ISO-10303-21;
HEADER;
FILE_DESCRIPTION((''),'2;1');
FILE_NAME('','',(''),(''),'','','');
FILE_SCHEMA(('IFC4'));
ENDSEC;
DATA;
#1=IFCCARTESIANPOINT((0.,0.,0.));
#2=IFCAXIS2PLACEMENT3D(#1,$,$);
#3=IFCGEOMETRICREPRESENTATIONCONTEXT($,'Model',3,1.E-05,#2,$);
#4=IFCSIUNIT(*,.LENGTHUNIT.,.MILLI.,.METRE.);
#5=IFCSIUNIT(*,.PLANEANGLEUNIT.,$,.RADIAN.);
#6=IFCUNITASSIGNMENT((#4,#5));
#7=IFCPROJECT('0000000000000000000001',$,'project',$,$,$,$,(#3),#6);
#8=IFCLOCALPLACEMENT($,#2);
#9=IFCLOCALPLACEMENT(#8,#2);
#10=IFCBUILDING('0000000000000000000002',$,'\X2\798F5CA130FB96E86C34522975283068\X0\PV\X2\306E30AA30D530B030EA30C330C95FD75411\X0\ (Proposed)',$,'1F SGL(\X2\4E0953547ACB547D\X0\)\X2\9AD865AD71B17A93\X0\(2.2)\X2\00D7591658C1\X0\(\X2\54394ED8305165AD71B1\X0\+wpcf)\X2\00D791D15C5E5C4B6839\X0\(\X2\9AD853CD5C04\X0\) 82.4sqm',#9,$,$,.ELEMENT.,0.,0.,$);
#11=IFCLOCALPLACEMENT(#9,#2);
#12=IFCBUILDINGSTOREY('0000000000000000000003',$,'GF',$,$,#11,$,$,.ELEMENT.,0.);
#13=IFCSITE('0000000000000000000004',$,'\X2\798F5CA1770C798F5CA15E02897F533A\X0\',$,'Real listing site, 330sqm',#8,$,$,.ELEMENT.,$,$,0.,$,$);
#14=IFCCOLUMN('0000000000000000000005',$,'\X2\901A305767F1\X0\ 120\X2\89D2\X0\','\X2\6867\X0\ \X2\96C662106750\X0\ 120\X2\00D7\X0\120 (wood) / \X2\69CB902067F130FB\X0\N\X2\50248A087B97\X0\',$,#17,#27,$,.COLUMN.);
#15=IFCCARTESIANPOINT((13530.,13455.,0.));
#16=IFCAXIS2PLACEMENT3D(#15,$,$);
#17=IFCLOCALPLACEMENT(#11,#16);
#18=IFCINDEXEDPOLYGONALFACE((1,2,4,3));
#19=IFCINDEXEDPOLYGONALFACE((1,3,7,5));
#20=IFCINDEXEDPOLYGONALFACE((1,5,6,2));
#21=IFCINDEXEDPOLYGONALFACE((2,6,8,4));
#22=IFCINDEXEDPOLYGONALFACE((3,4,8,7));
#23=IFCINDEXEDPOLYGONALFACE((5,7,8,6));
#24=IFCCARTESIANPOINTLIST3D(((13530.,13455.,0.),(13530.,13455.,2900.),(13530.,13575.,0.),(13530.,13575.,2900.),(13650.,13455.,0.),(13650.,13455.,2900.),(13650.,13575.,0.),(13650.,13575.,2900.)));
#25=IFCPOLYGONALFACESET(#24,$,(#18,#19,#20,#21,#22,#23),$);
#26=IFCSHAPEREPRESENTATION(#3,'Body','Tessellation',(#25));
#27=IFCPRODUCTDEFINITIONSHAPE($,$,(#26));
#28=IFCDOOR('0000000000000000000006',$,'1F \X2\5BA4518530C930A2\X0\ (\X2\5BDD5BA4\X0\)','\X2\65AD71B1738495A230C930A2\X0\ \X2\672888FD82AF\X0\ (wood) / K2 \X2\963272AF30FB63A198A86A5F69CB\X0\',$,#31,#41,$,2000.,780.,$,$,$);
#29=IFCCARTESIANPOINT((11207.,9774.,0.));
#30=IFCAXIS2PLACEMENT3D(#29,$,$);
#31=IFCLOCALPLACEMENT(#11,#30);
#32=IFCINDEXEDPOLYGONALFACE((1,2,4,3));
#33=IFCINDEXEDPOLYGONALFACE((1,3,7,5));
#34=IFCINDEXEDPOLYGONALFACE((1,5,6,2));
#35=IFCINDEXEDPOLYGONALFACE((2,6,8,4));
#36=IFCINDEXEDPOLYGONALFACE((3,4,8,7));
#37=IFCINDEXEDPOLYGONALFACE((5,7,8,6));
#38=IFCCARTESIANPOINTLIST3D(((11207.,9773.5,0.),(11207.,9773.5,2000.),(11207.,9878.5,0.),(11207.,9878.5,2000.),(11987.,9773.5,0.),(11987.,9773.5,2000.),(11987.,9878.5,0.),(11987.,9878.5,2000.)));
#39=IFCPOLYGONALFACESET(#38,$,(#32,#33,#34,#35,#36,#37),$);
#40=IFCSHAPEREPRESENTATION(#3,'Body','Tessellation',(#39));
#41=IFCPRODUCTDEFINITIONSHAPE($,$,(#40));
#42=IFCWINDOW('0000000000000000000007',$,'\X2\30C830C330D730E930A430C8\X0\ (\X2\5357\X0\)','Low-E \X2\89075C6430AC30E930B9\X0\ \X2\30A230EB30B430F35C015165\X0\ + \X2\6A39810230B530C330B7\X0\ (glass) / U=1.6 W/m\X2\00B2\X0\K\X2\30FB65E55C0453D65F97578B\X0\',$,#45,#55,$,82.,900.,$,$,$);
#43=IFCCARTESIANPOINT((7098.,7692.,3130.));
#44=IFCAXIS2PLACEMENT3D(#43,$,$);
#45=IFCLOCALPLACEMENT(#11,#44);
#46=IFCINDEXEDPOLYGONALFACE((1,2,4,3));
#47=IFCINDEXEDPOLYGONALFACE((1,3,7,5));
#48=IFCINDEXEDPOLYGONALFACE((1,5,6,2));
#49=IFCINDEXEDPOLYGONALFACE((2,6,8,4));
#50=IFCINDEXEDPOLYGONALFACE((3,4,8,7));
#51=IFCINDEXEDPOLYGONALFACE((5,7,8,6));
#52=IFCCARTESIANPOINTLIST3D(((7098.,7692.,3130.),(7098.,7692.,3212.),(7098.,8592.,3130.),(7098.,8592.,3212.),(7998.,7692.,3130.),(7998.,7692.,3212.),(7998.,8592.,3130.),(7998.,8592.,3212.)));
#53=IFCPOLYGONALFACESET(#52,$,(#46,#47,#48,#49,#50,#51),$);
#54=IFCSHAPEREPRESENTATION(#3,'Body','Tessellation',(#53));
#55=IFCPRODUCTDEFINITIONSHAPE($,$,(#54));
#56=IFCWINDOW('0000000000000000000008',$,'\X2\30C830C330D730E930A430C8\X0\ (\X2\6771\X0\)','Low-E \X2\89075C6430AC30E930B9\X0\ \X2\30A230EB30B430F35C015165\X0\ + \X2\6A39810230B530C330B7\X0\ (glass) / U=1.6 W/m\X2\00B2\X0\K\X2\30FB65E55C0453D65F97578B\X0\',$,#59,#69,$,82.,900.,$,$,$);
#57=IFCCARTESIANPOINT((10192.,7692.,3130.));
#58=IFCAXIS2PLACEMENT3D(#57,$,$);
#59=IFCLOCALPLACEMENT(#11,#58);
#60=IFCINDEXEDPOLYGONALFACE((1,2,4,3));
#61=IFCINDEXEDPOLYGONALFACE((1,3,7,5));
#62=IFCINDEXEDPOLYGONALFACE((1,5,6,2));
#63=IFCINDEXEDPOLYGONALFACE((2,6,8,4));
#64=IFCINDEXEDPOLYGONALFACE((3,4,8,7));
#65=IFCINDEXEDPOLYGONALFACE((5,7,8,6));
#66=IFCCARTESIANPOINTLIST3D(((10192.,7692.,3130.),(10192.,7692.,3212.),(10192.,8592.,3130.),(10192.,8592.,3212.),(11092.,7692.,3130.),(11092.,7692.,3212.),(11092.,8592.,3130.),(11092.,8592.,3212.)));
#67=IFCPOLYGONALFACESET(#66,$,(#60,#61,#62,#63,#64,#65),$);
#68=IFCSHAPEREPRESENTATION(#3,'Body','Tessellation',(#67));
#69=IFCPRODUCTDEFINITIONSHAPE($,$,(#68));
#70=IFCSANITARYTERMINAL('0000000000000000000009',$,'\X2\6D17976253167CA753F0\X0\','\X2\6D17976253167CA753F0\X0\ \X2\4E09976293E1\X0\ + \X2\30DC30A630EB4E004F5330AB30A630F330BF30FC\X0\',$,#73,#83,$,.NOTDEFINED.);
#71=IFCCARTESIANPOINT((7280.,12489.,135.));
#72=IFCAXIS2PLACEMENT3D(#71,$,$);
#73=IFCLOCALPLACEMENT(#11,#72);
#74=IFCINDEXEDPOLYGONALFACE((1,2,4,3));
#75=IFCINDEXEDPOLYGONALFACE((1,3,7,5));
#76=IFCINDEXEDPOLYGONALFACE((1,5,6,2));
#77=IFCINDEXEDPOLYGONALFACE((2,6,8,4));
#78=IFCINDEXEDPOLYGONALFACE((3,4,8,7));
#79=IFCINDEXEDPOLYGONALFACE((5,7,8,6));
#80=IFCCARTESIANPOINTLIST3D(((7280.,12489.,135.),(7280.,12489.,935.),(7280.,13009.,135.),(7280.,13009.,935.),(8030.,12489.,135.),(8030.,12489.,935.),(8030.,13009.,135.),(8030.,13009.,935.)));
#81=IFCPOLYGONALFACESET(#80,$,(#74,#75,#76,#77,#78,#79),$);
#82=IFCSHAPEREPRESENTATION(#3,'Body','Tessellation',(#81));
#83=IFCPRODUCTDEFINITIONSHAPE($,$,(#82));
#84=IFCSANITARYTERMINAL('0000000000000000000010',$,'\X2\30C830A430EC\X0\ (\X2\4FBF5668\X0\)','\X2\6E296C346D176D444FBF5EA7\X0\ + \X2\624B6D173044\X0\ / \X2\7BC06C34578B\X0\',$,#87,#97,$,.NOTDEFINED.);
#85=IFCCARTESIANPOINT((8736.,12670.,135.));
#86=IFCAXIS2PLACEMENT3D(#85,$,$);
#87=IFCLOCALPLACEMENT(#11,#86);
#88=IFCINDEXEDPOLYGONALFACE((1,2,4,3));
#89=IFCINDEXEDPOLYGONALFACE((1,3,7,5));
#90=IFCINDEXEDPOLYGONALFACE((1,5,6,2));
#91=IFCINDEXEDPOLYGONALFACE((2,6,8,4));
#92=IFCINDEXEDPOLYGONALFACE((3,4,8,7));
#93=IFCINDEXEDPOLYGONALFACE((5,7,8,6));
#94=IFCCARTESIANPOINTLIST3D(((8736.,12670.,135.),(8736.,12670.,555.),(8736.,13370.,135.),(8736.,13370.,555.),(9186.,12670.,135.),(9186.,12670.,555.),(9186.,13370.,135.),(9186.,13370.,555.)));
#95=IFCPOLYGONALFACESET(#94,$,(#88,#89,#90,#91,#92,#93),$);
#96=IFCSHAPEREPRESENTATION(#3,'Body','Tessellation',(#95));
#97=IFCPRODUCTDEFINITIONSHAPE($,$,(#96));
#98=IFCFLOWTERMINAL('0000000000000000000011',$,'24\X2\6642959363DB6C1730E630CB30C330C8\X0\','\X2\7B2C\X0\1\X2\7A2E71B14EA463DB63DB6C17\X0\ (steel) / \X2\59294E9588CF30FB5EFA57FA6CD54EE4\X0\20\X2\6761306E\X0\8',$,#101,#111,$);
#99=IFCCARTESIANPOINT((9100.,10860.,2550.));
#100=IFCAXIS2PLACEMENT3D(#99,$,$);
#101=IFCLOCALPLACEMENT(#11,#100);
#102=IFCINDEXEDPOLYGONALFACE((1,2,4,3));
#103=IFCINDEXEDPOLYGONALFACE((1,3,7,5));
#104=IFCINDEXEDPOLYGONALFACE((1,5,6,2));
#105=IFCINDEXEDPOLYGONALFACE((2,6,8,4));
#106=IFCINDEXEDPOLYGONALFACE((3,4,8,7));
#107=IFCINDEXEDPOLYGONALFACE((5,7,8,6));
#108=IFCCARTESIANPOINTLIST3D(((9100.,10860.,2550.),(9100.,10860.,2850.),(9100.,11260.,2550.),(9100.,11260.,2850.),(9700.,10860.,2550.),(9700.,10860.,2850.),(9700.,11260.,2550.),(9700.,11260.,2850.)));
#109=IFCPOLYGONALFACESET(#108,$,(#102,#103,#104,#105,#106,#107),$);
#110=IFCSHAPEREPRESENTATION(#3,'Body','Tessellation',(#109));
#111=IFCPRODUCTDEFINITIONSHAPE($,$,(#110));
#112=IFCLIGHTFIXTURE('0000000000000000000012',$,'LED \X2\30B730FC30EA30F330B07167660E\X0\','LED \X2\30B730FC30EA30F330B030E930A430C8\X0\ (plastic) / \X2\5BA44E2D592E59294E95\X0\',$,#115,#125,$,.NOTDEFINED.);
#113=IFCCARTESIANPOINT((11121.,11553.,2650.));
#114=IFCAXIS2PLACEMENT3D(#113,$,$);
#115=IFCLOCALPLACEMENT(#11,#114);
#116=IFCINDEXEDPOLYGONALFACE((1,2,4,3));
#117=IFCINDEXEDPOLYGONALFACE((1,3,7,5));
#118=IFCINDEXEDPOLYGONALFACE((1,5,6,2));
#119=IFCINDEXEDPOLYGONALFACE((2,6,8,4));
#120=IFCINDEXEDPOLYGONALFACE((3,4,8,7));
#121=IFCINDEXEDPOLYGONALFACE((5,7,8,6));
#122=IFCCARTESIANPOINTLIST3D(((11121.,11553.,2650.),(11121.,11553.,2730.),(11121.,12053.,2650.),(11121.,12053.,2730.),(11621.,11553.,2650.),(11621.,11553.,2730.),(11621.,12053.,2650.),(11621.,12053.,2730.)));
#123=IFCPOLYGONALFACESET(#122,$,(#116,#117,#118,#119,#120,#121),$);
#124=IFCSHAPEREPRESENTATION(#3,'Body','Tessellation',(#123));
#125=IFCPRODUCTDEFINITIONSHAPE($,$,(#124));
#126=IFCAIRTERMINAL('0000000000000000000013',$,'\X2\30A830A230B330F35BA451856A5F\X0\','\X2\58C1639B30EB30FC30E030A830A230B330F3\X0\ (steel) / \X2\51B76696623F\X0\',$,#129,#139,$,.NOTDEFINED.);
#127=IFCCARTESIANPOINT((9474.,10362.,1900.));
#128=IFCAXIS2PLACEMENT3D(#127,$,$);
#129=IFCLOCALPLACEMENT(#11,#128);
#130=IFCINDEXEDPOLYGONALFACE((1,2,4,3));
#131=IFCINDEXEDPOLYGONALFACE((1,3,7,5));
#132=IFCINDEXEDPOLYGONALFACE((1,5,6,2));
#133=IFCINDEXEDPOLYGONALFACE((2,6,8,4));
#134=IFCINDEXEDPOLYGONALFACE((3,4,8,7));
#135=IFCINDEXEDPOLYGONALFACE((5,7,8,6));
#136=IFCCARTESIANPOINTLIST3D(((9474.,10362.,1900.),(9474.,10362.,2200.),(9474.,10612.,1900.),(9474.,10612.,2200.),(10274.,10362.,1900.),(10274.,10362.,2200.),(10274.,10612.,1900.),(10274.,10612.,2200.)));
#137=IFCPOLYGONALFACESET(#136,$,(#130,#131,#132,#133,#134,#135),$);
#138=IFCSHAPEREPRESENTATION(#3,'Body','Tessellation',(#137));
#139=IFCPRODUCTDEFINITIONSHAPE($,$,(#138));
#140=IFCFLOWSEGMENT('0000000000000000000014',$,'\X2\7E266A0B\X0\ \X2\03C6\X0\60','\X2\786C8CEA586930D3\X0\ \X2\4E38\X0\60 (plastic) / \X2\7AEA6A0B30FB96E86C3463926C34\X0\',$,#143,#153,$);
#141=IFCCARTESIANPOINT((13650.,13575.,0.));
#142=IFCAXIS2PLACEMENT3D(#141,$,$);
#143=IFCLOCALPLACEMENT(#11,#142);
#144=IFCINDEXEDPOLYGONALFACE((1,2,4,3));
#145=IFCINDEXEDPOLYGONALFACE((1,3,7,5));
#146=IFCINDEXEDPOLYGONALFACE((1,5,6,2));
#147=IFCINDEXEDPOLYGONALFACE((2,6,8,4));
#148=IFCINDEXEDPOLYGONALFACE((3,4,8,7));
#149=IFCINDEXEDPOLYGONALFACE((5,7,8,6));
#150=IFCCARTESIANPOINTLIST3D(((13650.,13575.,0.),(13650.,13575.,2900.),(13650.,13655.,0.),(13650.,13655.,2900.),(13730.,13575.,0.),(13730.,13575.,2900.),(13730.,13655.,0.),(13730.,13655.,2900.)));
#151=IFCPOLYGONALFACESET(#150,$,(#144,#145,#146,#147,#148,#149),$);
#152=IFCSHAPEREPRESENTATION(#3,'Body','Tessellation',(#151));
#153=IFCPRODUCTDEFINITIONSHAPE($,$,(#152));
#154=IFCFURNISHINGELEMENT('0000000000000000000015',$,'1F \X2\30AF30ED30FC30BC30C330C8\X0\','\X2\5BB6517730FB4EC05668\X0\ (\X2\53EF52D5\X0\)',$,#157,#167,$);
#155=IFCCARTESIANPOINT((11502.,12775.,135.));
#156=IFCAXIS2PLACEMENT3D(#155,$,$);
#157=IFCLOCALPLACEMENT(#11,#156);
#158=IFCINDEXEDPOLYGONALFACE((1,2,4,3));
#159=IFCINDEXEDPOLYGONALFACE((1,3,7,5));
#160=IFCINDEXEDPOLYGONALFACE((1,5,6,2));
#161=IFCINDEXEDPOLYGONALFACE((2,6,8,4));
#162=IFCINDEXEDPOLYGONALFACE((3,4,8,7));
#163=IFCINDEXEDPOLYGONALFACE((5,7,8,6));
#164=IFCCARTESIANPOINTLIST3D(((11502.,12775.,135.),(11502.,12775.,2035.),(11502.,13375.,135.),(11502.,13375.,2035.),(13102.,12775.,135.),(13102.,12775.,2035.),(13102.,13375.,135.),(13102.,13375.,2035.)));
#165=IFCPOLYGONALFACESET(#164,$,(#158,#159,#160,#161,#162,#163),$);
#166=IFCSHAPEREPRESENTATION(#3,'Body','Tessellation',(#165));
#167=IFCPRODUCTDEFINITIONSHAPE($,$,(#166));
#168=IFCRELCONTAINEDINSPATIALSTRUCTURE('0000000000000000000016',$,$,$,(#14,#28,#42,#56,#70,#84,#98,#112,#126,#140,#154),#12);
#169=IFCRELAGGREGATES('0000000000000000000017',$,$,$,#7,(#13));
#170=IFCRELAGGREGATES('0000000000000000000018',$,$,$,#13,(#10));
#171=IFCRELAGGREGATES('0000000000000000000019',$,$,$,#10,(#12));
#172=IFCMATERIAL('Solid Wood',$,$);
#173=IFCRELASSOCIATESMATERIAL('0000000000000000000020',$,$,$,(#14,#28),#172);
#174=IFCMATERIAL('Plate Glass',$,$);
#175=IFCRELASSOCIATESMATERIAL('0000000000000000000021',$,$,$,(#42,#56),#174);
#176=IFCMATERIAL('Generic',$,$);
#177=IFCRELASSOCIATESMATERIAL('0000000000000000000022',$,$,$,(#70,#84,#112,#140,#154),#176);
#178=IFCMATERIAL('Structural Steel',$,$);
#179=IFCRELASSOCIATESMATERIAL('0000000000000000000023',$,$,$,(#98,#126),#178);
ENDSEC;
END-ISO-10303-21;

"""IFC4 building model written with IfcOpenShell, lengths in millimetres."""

from ifc_helpers import new_model, si_unit, frame, frame_2d, origin, place, context, project, spatial, rectangle, extrude, material, element, save


model = new_model("IFC4")

# Units and contexts
model_context = context("Model", 3, precision=1e-05, world=origin())
ifc_project = project(units=[si_unit("LENGTHUNIT", "METRE", prefix="MILLI"), si_unit("PLANEANGLEUNIT", "RADIAN")], contexts=[model_context])

# Site, building, storey
site_placement = place(None, origin())
site = spatial("IfcSite", under=ifc_project, at=site_placement, Name="福岡県福岡市西区", ObjectType="Real listing site, 330sqm", CompositionType="ELEMENT", RefElevation=0.0)
building_placement = place(site_placement, origin())
building = spatial("IfcBuilding", under=site, at=building_placement, Name="福岡・雨水利用とPVのオフグリッド志向 (Proposed)", ObjectType="1F SGL(三協立命)高断熱窓(2.2)×外壁(吹付け断熱+wpcf)×金属屋根(高反射) 82.4sqm", CompositionType="ELEMENT", ElevationOfRefHeight=0.0, ElevationOfTerrain=0.0)
storey_placement = place(building_placement, origin())
storey = spatial("IfcBuildingStorey", under=building, at=storey_placement, Name="GF", CompositionType="ELEMENT", Elevation=0.0)

# Column
ifc_material_1 = material(Name="Solid Wood")
column_1_placement = place(storey_placement, frame((13530.0, 13455.0, 0.0)))
element("IfcColumn", 1, at=column_1_placement, inside=storey, material=ifc_material_1, Name="通し柱 120角", Description="桧 集成材 120×120 (wood) / 構造柱・N値計算", PredefinedType="COLUMN", context=model_context, shape_type="SweptSolid", body=[
    extrude(rectangle(XDim=120.0, YDim=120.0, at=frame_2d((60.0, 60.0))), frame((13530.0, 13455.0, 0.0)), (0.0, 0.0, 1.0), 2900.0),
])

# Door
door_placement = place(storey_placement, frame((11207.0, 9774.0, 0.0)))
element("IfcDoor", 2, at=door_placement, inside=storey, material=ifc_material_1, Name="1F 室内ドア (寝室)", Description="断熱玄関ドア 木製芯 (wood) / K2 防犯・採風機構", OverallHeight=2000.0, OverallWidth=780.0, context=model_context, shape_type="SweptSolid", body=[
    extrude(rectangle(XDim=780.0, YDim=105.0, at=frame_2d((390.0, 52.0))), frame((11207.0, 9774.0, 0.0)), (0.0, 0.0, 1.0), 2000.0),
])

# Windows
ifc_material_2 = material(Name="Plate Glass")
window_1_placement = place(storey_placement, frame((7098.0, 7692.0, 3130.0)))
element("IfcWindow", 3, at=window_1_placement, inside=storey, material=ifc_material_2, Name="トップライト (南)", Description="Low-E 複層ガラス アルゴン封入 + 樹脂サッシ (glass) / U=1.6 W/m²K・日射取得型", OverallHeight=82.0, OverallWidth=900.0, context=model_context, shape_type="SweptSolid", body=[
    extrude(rectangle(XDim=900.0, YDim=900.0, at=frame_2d((450.0, 450.0))), frame((7098.0, 7692.0, 3130.0)), (0.0, 0.0, 1.0), 82.0),
])
window_2_placement = place(storey_placement, frame((10192.0, 7692.0, 3130.0)))
element("IfcWindow", 4, at=window_2_placement, inside=storey, material=ifc_material_2, Name="トップライト (東)", Description="Low-E 複層ガラス アルゴン封入 + 樹脂サッシ (glass) / U=1.6 W/m²K・日射取得型", OverallHeight=82.0, OverallWidth=900.0, context=model_context, shape_type="SweptSolid", body=[
    extrude(rectangle(XDim=900.0, YDim=900.0, at=frame_2d((450.0, 450.0))), frame((10192.0, 7692.0, 3130.0)), (0.0, 0.0, 1.0), 82.0),
])

# Sanitary terminals
ifc_material_3 = material(Name="Generic")
sanitary_terminal_1_placement = place(storey_placement, frame((7280.0, 12489.0, 135.0)))
element("IfcSanitaryTerminal", 5, at=sanitary_terminal_1_placement, inside=storey, material=ifc_material_3, Name="洗面化粧台", Description="洗面化粧台 三面鏡 + ボウル一体カウンター", PredefinedType="NOTDEFINED", context=model_context, shape_type="SweptSolid", body=[
    extrude(rectangle(XDim=750.0, YDim=520.0, at=frame_2d((375.0, 260.0))), frame((7280.0, 12489.0, 135.0)), (0.0, 0.0, 1.0), 800.0),
])
sanitary_terminal_2_placement = place(storey_placement, frame((8736.0, 12670.0, 135.0)))
element("IfcSanitaryTerminal", 6, at=sanitary_terminal_2_placement, inside=storey, material=ifc_material_3, Name="トイレ (便器)", Description="温水洗浄便座 + 手洗い / 節水型", PredefinedType="NOTDEFINED", context=model_context, shape_type="SweptSolid", body=[
    extrude(rectangle(XDim=450.0, YDim=700.0, at=frame_2d((225.0, 350.0))), frame((8736.0, 12670.0, 135.0)), (0.0, 0.0, 1.0), 420.0),
])

# Flow terminal
ifc_material_4 = material(Name="Structural Steel")
flow_terminal_placement = place(storey_placement, frame((9100.0, 10860.0, 2550.0)))
element("IfcFlowTerminal", 7, at=flow_terminal_placement, inside=storey, material=ifc_material_4, Name="24時間換気ユニット", Description="第1種熱交換換気 (steel) / 天井裏・建基法令20条の8", context=model_context, shape_type="SweptSolid", body=[
    extrude(rectangle(XDim=600.0, YDim=400.0, at=frame_2d((300.0, 200.0))), frame((9100.0, 10860.0, 2550.0)), (0.0, 0.0, 1.0), 300.0),
])

# Light fixture
light_fixture_placement = place(storey_placement, frame((11121.0, 11553.0, 2650.0)))
element("IfcLightFixture", 8, at=light_fixture_placement, inside=storey, material=ifc_material_3, Name="LED シーリング照明", Description="LED シーリングライト (plastic) / 室中央天井", PredefinedType="NOTDEFINED", context=model_context, shape_type="SweptSolid", body=[
    extrude(rectangle(XDim=500.0, YDim=500.0, at=frame_2d((250.0, 250.0))), frame((11121.0, 11553.0, 2650.0)), (0.0, 0.0, 1.0), 80.0),
])

# Air terminal
air_terminal_placement = place(storey_placement, frame((9474.0, 10362.0, 1900.0)))
element("IfcAirTerminal", 9, at=air_terminal_placement, inside=storey, material=ifc_material_4, Name="エアコン室内機", Description="壁掛ルームエアコン (steel) / 冷暖房", PredefinedType="NOTDEFINED", context=model_context, shape_type="SweptSolid", body=[
    extrude(rectangle(XDim=800.0, YDim=250.0, at=frame_2d((400.0, 125.0))), frame((9474.0, 10362.0, 1900.0)), (0.0, 0.0, 1.0), 300.0),
])

# Flow segment
flow_segment_placement = place(storey_placement, frame((13650.0, 13575.0, 0.0)))
element("IfcFlowSegment", 10, at=flow_segment_placement, inside=storey, material=ifc_material_3, Name="縦樋 φ60", Description="硬質塩ビ 丸60 (plastic) / 竪樋・雨水排水", context=model_context, shape_type="SweptSolid", body=[
    extrude(rectangle(XDim=80.0, YDim=80.0, at=frame_2d((40.0, 40.0))), frame((13650.0, 13575.0, 0.0)), (0.0, 0.0, 1.0), 2900.0),
])

# Furnishing element
furnishing_placement = place(storey_placement, frame((11502.0, 12775.0, 135.0)))
element("IfcFurnishingElement", 11, at=furnishing_placement, inside=storey, material=ifc_material_3, Name="1F クローゼット", Description="家具・什器 (可動)", context=model_context, shape_type="SweptSolid", body=[
    extrude(rectangle(XDim=1600.0, YDim=600.0, at=frame_2d((800.0, 300.0))), frame((11502.0, 12775.0, 135.0)), (0.0, 0.0, 1.0), 1900.0),
])

save(model, "model.ifc")
